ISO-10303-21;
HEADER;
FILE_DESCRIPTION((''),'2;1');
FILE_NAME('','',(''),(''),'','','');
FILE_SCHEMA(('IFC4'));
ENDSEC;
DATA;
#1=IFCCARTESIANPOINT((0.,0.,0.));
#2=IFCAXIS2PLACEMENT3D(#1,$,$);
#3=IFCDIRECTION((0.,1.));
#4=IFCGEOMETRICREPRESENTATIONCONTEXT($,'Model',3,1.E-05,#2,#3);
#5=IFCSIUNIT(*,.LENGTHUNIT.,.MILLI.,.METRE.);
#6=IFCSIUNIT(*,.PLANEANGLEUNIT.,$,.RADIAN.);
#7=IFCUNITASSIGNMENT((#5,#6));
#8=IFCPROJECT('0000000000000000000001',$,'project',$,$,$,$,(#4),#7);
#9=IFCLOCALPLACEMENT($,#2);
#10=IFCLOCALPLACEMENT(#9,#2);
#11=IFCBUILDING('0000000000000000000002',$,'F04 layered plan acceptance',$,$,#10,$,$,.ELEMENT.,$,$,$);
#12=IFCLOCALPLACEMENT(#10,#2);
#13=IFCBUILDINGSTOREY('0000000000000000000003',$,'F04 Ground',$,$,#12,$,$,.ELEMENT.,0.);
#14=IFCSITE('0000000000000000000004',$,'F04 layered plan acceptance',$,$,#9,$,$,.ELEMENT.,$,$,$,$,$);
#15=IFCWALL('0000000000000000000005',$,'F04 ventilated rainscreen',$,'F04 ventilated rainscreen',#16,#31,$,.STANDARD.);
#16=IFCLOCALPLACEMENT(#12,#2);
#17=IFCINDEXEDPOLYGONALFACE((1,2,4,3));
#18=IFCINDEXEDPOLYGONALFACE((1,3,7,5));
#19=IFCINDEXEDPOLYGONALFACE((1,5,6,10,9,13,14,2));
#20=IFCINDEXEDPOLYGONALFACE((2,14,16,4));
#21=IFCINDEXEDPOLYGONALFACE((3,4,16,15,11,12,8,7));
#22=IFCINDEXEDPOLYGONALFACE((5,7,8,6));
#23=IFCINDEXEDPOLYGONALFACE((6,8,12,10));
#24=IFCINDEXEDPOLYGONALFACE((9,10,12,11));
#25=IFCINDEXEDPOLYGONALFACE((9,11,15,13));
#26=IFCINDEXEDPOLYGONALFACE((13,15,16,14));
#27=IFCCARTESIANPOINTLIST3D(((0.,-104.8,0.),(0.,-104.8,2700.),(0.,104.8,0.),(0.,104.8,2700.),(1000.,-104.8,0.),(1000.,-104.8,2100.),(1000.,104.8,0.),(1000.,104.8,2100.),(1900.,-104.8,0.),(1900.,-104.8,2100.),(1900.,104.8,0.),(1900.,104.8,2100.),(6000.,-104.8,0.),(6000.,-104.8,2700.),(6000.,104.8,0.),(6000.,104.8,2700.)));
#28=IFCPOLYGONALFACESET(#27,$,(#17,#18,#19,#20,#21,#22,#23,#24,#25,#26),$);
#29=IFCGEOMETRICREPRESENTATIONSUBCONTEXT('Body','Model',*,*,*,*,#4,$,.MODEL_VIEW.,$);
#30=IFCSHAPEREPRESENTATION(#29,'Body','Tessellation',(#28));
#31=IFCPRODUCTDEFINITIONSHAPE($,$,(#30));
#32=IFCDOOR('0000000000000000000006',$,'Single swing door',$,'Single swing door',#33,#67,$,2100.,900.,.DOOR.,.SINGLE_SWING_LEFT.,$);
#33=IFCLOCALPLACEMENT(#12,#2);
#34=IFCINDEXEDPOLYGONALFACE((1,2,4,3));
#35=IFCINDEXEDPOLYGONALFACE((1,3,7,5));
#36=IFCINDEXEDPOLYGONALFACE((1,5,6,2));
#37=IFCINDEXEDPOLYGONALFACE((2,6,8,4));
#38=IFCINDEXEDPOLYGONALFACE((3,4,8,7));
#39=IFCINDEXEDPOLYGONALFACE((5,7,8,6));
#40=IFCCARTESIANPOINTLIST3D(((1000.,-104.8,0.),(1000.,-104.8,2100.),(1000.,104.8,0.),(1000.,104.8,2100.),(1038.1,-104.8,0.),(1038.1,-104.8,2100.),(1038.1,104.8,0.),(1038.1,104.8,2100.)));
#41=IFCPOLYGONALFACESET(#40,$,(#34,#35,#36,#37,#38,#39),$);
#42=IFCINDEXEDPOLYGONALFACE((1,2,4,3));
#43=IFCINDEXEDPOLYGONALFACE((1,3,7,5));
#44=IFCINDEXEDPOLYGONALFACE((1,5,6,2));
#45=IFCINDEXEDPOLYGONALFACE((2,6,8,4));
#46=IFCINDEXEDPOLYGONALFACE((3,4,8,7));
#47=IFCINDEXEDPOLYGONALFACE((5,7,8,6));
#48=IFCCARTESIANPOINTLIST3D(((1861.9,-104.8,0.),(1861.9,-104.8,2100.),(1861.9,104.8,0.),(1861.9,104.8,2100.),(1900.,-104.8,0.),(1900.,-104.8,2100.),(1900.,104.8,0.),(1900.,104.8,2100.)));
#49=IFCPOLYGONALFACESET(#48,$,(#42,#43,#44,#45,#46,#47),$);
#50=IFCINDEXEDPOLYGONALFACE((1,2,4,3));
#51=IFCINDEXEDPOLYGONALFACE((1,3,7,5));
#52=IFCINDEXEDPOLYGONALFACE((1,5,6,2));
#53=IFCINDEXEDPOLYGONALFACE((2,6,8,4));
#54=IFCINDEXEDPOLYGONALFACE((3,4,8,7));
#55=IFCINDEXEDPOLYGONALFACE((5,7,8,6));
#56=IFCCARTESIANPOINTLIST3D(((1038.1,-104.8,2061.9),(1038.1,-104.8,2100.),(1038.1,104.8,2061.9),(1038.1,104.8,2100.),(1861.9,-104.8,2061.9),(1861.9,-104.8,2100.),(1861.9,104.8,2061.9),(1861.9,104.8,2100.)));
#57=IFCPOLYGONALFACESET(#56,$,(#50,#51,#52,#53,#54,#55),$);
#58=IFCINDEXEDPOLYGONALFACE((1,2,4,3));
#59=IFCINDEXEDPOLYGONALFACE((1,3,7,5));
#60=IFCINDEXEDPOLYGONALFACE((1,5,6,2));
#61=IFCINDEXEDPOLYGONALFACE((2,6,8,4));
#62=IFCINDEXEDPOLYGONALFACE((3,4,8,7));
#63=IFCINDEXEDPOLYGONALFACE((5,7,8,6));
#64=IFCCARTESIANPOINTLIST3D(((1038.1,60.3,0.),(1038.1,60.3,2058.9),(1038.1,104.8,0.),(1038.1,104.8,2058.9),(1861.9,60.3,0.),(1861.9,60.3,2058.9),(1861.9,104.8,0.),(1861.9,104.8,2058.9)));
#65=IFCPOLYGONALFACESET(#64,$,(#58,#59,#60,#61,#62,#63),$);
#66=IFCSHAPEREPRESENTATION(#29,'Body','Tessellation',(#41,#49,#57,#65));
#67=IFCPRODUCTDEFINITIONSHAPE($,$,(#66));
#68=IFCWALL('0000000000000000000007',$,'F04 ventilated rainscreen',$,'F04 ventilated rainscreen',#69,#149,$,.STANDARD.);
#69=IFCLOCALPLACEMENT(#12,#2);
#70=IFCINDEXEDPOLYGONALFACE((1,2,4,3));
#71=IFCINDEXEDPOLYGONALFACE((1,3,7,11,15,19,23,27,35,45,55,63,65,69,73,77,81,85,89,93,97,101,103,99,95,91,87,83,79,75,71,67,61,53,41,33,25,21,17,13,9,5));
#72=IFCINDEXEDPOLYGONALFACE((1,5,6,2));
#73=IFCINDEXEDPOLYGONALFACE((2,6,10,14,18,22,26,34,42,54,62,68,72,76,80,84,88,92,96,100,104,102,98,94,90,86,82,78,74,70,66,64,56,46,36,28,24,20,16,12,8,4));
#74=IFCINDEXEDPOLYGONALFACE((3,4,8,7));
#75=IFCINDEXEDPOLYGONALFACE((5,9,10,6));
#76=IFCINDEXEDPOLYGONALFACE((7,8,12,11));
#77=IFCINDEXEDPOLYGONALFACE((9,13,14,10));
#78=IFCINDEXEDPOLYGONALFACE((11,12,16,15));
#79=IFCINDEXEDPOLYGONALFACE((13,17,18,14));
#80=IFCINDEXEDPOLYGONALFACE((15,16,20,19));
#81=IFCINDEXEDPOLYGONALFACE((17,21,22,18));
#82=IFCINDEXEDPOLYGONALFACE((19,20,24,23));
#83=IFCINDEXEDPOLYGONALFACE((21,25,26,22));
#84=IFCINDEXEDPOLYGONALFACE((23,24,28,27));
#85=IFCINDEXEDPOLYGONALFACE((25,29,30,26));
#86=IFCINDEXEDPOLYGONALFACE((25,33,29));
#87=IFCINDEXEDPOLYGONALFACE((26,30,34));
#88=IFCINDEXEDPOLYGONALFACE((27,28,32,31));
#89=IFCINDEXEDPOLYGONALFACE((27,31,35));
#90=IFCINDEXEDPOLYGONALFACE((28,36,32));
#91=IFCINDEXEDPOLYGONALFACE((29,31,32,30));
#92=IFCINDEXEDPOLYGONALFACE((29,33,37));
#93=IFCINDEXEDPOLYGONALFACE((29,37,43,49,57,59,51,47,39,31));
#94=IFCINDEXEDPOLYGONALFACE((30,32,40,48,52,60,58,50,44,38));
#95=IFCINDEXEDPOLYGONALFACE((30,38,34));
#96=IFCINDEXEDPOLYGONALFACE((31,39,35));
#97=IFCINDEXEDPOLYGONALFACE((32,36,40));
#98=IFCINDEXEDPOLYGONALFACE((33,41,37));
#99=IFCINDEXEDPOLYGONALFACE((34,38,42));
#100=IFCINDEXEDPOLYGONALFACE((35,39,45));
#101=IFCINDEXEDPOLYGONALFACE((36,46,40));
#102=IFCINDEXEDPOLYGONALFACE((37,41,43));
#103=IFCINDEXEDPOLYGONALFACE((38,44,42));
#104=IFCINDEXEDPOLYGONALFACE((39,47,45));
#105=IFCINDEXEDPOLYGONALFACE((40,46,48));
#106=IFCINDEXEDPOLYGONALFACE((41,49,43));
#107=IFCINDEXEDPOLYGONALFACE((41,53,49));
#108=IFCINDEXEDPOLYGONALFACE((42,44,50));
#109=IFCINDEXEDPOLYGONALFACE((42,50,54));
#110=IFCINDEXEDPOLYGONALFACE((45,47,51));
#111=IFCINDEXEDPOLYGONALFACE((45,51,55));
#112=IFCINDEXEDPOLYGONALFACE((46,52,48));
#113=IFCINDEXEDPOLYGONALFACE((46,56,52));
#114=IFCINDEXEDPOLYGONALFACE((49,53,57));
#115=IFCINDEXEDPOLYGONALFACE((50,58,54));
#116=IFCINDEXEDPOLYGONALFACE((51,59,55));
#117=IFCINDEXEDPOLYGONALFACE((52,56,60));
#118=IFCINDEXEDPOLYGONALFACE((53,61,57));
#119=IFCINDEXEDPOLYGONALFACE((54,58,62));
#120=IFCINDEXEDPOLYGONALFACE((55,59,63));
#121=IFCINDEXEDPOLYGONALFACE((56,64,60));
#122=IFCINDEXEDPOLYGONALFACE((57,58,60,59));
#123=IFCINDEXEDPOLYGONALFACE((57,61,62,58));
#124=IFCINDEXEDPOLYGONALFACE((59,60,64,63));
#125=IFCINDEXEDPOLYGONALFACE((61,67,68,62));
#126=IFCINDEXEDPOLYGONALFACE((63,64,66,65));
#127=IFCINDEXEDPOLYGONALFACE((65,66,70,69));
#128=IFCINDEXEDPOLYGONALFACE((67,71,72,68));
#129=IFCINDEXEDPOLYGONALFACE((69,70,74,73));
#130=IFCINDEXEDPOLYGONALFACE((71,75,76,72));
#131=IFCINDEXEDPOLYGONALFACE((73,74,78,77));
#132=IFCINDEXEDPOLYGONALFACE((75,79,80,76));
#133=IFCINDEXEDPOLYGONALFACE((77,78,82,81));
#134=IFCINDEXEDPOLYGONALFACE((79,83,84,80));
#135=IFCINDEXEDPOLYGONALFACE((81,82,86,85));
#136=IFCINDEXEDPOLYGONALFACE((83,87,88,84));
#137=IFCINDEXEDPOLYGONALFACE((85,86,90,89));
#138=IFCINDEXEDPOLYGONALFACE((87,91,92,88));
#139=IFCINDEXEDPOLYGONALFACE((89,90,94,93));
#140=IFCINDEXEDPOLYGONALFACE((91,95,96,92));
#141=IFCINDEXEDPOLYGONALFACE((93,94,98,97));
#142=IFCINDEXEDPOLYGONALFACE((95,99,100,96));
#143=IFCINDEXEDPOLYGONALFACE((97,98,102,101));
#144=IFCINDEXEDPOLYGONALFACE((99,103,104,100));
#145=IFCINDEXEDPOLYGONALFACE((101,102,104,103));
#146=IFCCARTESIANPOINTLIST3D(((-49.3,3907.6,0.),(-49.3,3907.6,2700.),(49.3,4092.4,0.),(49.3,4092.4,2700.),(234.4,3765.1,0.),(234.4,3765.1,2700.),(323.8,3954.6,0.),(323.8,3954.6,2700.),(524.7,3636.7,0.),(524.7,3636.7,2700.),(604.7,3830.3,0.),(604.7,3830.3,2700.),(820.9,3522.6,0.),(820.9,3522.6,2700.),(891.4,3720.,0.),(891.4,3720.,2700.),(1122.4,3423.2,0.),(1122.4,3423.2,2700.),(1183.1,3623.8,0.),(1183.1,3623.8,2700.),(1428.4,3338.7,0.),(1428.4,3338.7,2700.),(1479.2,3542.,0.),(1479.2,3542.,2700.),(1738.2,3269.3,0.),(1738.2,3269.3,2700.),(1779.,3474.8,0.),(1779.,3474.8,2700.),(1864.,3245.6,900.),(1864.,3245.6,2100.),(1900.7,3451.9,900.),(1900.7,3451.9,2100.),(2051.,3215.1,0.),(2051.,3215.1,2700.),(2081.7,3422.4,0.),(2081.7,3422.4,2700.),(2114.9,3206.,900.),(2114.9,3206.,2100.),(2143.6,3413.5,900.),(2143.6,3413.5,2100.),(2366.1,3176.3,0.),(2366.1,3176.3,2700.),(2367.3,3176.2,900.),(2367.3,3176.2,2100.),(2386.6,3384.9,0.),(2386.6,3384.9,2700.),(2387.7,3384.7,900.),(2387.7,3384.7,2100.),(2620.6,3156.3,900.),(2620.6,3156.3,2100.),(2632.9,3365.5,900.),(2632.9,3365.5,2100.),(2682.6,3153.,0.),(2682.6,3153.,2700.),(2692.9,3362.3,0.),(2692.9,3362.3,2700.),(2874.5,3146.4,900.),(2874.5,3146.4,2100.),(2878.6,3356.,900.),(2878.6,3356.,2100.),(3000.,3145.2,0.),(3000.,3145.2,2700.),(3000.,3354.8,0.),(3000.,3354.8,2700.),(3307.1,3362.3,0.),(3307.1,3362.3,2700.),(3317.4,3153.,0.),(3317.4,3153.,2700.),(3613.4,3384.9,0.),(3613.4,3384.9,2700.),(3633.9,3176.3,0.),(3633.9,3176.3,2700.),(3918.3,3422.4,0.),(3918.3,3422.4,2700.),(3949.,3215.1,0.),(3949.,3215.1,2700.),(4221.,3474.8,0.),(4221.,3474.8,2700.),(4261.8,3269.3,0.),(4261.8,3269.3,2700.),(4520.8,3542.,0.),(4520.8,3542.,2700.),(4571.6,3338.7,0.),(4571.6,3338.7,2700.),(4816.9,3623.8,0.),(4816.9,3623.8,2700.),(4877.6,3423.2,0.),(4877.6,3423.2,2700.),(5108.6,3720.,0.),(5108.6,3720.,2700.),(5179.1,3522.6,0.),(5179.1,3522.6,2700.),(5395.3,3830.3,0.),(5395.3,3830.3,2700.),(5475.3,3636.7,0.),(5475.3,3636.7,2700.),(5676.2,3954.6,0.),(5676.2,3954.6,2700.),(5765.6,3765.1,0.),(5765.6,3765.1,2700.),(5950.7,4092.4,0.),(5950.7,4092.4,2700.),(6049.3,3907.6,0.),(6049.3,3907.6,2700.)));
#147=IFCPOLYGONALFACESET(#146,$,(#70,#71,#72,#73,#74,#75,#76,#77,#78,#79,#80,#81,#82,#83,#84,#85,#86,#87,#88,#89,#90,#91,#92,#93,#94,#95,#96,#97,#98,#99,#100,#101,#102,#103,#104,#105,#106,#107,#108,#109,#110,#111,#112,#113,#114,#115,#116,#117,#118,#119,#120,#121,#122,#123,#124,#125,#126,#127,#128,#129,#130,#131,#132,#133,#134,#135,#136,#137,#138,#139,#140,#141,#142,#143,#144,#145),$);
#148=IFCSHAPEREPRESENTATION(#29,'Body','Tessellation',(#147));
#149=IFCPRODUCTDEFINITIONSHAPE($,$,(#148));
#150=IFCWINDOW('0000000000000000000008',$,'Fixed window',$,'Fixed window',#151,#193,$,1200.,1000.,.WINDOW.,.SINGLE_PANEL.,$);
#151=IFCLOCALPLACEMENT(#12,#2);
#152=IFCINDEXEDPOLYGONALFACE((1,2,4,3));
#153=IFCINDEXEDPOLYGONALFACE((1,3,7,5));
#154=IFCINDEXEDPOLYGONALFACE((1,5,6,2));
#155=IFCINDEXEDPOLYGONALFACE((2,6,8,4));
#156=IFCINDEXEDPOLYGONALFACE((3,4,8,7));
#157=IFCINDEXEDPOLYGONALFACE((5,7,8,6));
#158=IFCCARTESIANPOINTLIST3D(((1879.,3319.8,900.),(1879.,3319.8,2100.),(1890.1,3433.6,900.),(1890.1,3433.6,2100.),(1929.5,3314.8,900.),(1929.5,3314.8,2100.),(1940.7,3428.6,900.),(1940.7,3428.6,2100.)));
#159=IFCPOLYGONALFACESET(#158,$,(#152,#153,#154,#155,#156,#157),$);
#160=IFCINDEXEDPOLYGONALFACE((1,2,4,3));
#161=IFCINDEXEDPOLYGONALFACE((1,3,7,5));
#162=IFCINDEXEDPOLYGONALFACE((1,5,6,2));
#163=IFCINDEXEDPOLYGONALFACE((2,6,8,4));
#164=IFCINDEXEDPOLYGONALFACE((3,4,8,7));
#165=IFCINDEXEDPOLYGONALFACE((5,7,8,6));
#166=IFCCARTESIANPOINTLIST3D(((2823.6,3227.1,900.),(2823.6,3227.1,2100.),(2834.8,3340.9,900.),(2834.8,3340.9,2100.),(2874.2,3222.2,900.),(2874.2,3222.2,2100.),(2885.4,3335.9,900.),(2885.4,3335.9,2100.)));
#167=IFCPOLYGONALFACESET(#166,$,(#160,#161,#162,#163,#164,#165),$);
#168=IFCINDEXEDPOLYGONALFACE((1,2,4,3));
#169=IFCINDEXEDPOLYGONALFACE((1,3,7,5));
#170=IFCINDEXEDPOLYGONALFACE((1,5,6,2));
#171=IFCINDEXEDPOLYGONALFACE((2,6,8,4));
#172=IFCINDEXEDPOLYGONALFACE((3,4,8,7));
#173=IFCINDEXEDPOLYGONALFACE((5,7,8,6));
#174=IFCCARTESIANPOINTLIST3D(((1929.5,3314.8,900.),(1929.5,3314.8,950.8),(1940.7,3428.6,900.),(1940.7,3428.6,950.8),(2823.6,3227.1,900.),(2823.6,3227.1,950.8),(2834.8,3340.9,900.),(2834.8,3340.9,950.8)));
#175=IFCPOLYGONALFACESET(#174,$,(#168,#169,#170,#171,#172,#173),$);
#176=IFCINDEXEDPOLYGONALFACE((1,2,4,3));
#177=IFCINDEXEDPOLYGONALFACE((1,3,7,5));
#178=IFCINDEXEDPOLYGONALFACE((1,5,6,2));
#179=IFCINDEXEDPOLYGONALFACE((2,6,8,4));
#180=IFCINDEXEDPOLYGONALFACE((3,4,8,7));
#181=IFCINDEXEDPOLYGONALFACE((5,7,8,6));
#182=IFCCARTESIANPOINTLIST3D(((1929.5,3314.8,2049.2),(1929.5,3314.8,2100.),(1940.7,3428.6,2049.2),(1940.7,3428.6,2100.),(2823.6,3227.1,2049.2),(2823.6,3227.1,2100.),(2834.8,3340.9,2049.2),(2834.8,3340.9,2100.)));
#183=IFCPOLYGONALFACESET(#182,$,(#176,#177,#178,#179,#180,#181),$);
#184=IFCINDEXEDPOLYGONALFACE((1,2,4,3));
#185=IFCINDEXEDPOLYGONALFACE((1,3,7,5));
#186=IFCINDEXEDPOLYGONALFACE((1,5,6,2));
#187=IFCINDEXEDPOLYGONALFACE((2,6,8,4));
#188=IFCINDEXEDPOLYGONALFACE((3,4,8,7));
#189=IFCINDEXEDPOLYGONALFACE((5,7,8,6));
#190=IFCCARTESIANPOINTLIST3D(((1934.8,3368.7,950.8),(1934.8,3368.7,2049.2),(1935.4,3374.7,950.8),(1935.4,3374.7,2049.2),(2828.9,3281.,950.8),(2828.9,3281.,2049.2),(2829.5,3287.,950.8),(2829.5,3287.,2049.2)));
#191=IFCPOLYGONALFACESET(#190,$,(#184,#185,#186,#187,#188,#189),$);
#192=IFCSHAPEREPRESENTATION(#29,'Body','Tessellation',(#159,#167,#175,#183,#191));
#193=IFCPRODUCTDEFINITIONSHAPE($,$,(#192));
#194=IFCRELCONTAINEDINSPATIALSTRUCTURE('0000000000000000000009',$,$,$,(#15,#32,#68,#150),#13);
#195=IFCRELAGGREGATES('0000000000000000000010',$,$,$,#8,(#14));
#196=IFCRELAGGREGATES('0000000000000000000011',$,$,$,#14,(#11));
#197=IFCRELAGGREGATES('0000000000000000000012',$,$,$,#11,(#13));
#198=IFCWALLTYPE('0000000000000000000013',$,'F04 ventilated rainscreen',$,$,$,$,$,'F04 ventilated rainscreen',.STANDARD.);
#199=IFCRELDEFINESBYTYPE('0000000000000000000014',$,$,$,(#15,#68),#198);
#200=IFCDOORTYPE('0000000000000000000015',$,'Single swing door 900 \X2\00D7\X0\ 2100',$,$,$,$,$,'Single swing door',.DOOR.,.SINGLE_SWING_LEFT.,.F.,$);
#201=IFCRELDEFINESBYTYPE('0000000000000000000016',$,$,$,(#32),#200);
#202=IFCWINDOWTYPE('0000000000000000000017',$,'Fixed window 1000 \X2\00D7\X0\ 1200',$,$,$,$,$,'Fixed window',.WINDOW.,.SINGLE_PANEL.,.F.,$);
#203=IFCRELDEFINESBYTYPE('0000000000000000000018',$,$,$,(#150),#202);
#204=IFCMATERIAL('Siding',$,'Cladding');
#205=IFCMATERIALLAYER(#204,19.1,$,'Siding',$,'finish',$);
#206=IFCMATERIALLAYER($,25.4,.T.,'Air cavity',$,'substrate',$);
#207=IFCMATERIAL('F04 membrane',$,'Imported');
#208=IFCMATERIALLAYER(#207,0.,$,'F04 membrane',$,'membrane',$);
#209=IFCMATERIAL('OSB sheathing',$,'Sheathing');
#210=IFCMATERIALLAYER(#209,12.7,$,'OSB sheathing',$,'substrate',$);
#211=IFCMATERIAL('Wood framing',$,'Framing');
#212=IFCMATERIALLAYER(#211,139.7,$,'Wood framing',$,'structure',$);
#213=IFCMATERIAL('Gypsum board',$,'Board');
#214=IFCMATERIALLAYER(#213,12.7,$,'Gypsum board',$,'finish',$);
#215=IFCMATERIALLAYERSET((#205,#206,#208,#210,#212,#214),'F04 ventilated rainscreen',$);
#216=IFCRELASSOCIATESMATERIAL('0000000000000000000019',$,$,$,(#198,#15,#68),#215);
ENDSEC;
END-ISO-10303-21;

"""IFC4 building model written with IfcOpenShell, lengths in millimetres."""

from ifc_helpers import new_model, si_unit, direction, frame, origin, origin_with_axes, place, context, subcontext, project, spatial, polyline, line, arc, indexed_curve, outline, extrude, material, layer, layer_set, layer_usage, type_object, element, fill, save


model = new_model("IFC4")

# Units and contexts
model_context = context("Model", 3, precision=1e-05, world=origin(), true_north=direction((0.0, 1.0)))
body_context = subcontext(model_context, "Body", "Model", "MODEL_VIEW")
ifc_project = project(units=[si_unit("LENGTHUNIT", "METRE", prefix="MILLI"), si_unit("PLANEANGLEUNIT", "RADIAN")], contexts=[model_context])

# Site, building, storey
site_placement = place(None, origin())
site = spatial("IfcSite", under=ifc_project, at=site_placement, Name="F04 layered plan acceptance", CompositionType="ELEMENT")
building_placement = place(site_placement, origin())
building = spatial("IfcBuilding", under=site, at=building_placement, Name="F04 layered plan acceptance", CompositionType="ELEMENT")
storey_placement = place(building_placement, origin())
storey = spatial("IfcBuildingStorey", under=building, at=storey_placement, Name="F04 Ground", CompositionType="ELEMENT", Elevation=0.0)

# Wall, opening, door
ifc_material_1 = material(Name="Siding", Category="Cladding")
ifc_layer_1 = layer(ifc_material_1, 19.1, Name="Siding", Category="finish")
ifc_layer_2 = layer(None, 25.4, ventilated=True, Name="Air cavity", Category="substrate")
ifc_material_2 = material(Name="F04 membrane", Category="Imported")
ifc_layer_3 = layer(ifc_material_2, 0.0, Name="F04 membrane", Category="membrane")
ifc_material_3 = material(Name="OSB sheathing", Category="Sheathing")
ifc_layer_4 = layer(ifc_material_3, 12.7, Name="OSB sheathing", Category="substrate")
ifc_material_4 = material(Name="Wood framing", Category="Framing")
ifc_layer_5 = layer(ifc_material_4, 139.7, Name="Wood framing", Category="structure")
ifc_material_5 = material(Name="Gypsum board", Category="Board")
ifc_layer_6 = layer(ifc_material_5, 12.7, Name="Gypsum board", Category="finish")
ifc_layer_set_1 = layer_set([ifc_layer_1, ifc_layer_2, ifc_layer_3, ifc_layer_4, ifc_layer_5, ifc_layer_6], Name="F04 ventilated rainscreen")
ifc_layer_usage_1 = layer_usage(ifc_layer_set_1, "AXIS2", "NEGATIVE", 104.8)
wall_type_1 = type_object("IfcWallType", Name="F04 ventilated rainscreen", ElementType="F04 ventilated rainscreen", PredefinedType="STANDARD", material=ifc_layer_set_1)
wall_1_placement = place(storey_placement, origin_with_axes())
wall_1 = element("IfcWall", 1, at=wall_1_placement, inside=storey, type_object=wall_type_1, material=ifc_layer_usage_1, Name="F04 ventilated rainscreen", ObjectType="F04 ventilated rainscreen", PredefinedType="STANDARD", context=body_context, shape_type="SweptSolid", body=[
    extrude(outline(polyline([(0.0, -104.8), (6000.0, -104.8), (6000.0, 104.8), (0.0, 104.8), (0.0, -104.8)])), origin(), (0.0, 0.0, 1.0), 2700.0),
])
opening_1_placement = place(wall_1_placement, frame((1000.0, 0.0, 0.0), z_axis=(0.0, 0.0, 1.0), x_axis=(1.0, 0.0, 0.0)))
opening_1 = element("IfcOpeningElement", 2, at=opening_1_placement, cuts=wall_1, PredefinedType="OPENING", context=body_context, shape_type="SweptSolid", body=[
    extrude(outline(polyline([(0.0, -114.8), (900.0, -114.8), (900.0, 114.8), (0.0, 114.8), (0.0, -114.8)])), origin(), (0.0, 0.0, 1.0), 2100.0),
])
door_type = type_object("IfcDoorType", Name="Single swing door 900 × 2100", ElementType="Single swing door", OperationType="SINGLE_SWING_LEFT", ParameterTakesPrecedence=False, PredefinedType="DOOR")
door_1_placement = place(opening_1_placement, origin_with_axes())
door_1 = element("IfcDoor", 3, at=door_1_placement, inside=storey, type_object=door_type, Name="Single swing door", ObjectType="Single swing door", OperationType="SINGLE_SWING_LEFT", OverallHeight=2100.0, OverallWidth=900.0, PredefinedType="DOOR", context=body_context, shape_type="SweptSolid", body=[
    extrude(outline(polyline([(0.0, -104.8), (38.1, -104.8), (38.1, 104.8), (0.0, 104.8), (0.0, -104.8)])), origin(), (0.0, 0.0, 1.0), 2100.0),
    extrude(outline(polyline([(861.9, -104.8), (900.0, -104.8), (900.0, 104.8), (861.9, 104.8), (861.9, -104.8)])), origin(), (0.0, 0.0, 1.0), 2100.0),
    extrude(outline(polyline([(38.1, -104.8), (861.9, -104.8), (861.9, 104.8), (38.1, 104.8), (38.1, -104.8)])), frame((0.0, 0.0, 2061.9)), (0.0, 0.0, 1.0), 38.1),
    extrude(outline(polyline([(38.1, 60.3), (861.9, 60.3), (861.9, 104.8), (38.1, 104.8), (38.1, 60.3)])), origin(), (0.0, 0.0, 1.0), 2058.9),
])
fill(opening_1, door_1)

# Wall, opening, window
ifc_layer_usage_2 = layer_usage(ifc_layer_set_1, "AXIS2", "NEGATIVE", 104.8)
wall_2_placement = place(storey_placement, frame((0.0, 4000.0, 0.0), z_axis=(0.0, 0.0, 1.0), x_axis=(1.0, 0.0, 0.0)))
wall_2 = element("IfcWall", 4, at=wall_2_placement, inside=storey, type_object=wall_type_1, material=ifc_layer_usage_2, Name="F04 ventilated rainscreen", ObjectType="F04 ventilated rainscreen", PredefinedType="STANDARD", context=body_context, shape_type="SweptSolid", body=[
    extrude(outline(indexed_curve([(-49.3, -92.4), (3000.0, -854.8), (6049.3, -92.4), (5950.7, 92.4), (3000.0, -645.2), (49.3, 92.4)], segments=[arc(1, 2, 3), line(3, 4), arc(4, 5, 6), line(6, 1)], self_intersect=False)), origin(), (0.0, 0.0, 1.0), 2700.0),
])
opening_2_placement = place(wall_2_placement, frame((1879.9, -670.7, 900.0), z_axis=(0.0, 0.0, 1.0), x_axis=(0.995221, -0.097645, 0.0)))
opening_2 = element("IfcOpeningElement", 5, at=opening_2_placement, cuts=wall_2, PredefinedType="OPENING", context=body_context, shape_type="SweptSolid", body=[
    extrude(outline(polyline([(-10.0, -114.8), (1010.0, -114.8), (990.5, 134.0), (9.5, 134.0), (-10.0, -114.8)])), origin(), (0.0, 0.0, 1.0), 1200.0),
])
window_type_1 = type_object("IfcWindowType", Name="Fixed window 1000 × 1200", ElementType="Fixed window", ParameterTakesPrecedence=False, PartitioningType="SINGLE_PANEL", PredefinedType="WINDOW")
window_1_placement = place(opening_2_placement, origin_with_axes())
window_1 = element("IfcWindow", 6, at=window_1_placement, inside=storey, type_object=window_type_1, Name="Fixed window", ObjectType="Fixed window", OverallHeight=1200.0, OverallWidth=1000.0, PartitioningType="SINGLE_PANEL", PredefinedType="WINDOW", context=body_context, shape_type="SweptSolid", body=[
    extrude(outline(polyline([(0.0, -9.5), (50.8, -9.5), (50.8, 104.8), (0.0, 104.8), (0.0, -9.5)])), origin(), (0.0, 0.0, 1.0), 1200.0),
    extrude(outline(polyline([(949.2, -9.5), (1000.0, -9.5), (1000.0, 104.8), (949.2, 104.8), (949.2, -9.5)])), origin(), (0.0, 0.0, 1.0), 1200.0),
    extrude(outline(polyline([(50.8, -9.5), (949.2, -9.5), (949.2, 104.8), (50.8, 104.8), (50.8, -9.5)])), origin(), (0.0, 0.0, 1.0), 50.8),
    extrude(outline(polyline([(50.8, -9.5), (949.2, -9.5), (949.2, 104.8), (50.8, 104.8), (50.8, -9.5)])), frame((0.0, 0.0, 1149.2)), (0.0, 0.0, 1.0), 50.8),
    extrude(outline(polyline([(50.8, 44.6), (949.2, 44.6), (949.2, 50.6), (50.8, 50.6), (50.8, 44.6)])), frame((0.0, 0.0, 50.8)), (0.0, 0.0, 1.0), 1098.4),
])
fill(opening_2, window_1)

save(model, "model.ifc")
